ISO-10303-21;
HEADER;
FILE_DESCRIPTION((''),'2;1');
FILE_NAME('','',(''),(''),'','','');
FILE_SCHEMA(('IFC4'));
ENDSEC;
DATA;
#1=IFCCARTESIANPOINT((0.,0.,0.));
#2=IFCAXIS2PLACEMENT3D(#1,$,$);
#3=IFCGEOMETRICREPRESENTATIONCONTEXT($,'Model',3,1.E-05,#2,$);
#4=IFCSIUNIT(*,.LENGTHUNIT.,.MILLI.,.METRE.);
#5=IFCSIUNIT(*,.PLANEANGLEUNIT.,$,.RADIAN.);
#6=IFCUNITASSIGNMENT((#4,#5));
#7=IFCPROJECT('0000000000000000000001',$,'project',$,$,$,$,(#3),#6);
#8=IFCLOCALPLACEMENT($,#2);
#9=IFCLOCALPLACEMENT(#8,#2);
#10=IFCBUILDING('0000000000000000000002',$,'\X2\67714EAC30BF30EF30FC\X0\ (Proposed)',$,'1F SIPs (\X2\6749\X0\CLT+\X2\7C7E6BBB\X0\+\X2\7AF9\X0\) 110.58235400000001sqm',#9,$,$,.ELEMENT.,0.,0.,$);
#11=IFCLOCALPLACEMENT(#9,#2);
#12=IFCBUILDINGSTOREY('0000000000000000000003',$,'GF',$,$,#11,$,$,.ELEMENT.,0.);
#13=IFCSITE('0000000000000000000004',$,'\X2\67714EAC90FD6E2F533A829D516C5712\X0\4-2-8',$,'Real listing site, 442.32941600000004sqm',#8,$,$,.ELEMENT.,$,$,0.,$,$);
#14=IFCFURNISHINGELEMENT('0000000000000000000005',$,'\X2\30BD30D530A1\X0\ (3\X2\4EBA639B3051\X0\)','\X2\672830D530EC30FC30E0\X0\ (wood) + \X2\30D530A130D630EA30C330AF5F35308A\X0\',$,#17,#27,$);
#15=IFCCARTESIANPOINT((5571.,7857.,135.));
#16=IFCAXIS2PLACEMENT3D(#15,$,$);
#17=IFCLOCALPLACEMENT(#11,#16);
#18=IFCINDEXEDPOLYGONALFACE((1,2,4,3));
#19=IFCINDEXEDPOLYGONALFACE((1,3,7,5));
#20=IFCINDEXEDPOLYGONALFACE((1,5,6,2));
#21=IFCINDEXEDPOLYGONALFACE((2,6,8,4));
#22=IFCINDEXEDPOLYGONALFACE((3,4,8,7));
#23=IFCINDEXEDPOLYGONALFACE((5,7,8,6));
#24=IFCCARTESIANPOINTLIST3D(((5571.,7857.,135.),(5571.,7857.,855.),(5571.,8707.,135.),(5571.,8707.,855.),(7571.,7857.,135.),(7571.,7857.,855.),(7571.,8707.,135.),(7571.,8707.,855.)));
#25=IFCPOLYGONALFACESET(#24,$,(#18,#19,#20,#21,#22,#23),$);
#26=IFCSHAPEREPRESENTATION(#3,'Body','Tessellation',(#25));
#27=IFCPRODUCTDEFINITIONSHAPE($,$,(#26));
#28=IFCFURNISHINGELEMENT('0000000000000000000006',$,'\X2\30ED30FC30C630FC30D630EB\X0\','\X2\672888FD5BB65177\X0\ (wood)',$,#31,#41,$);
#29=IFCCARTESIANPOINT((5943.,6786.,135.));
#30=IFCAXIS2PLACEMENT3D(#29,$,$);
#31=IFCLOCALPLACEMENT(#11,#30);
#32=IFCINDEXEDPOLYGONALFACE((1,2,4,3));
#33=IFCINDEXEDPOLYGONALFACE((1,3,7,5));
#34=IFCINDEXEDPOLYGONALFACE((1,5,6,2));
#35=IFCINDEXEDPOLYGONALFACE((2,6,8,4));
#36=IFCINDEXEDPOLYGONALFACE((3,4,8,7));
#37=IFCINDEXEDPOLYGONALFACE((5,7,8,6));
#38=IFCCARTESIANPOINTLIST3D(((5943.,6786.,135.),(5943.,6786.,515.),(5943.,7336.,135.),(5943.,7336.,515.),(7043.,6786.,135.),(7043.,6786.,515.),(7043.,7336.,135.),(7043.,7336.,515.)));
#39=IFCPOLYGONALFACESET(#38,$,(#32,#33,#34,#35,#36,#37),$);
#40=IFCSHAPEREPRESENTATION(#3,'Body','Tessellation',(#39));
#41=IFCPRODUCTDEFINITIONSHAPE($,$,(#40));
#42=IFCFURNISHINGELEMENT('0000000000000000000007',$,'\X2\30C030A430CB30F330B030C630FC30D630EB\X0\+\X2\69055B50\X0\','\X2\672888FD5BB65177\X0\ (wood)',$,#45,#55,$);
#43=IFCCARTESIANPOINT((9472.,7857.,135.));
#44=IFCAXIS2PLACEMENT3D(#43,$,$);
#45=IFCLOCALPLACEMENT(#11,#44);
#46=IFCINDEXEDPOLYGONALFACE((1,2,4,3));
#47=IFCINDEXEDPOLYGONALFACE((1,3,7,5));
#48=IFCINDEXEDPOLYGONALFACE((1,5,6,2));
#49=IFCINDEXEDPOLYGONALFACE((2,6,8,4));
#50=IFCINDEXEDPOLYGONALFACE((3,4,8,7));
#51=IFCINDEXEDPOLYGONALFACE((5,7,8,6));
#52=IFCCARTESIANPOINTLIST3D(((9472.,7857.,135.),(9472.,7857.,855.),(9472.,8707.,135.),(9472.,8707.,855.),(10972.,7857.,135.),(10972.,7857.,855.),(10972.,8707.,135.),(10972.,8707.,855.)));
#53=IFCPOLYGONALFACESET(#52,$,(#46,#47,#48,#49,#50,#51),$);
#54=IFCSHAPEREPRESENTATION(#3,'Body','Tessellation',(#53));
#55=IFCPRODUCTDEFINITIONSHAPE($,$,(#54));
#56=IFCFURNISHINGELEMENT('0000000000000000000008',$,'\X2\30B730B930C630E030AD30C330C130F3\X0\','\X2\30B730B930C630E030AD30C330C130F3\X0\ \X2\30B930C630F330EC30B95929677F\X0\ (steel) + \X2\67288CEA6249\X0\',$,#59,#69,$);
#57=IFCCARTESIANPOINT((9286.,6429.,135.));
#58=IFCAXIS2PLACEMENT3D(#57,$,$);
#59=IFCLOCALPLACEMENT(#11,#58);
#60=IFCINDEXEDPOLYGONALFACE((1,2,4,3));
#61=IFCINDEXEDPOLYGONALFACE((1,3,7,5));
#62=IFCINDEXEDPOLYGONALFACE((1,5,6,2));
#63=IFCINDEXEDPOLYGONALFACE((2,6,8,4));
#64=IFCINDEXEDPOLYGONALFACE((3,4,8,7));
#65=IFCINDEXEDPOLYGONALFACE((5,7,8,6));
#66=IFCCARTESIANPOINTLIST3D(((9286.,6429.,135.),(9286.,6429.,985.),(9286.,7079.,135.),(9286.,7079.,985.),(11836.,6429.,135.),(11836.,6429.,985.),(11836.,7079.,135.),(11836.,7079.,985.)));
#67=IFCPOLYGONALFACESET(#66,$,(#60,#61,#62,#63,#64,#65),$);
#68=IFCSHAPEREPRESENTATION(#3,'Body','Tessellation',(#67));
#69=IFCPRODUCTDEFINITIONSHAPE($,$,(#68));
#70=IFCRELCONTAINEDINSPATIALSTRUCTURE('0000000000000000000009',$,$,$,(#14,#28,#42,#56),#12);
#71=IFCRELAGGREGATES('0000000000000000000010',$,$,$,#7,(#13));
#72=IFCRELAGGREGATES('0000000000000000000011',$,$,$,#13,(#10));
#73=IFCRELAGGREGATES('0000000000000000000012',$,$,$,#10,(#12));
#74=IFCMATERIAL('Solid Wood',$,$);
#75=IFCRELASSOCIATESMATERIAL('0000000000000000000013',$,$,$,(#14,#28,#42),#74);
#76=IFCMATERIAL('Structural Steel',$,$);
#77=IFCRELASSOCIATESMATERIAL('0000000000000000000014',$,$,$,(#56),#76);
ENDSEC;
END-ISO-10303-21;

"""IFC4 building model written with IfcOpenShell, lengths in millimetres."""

from ifc_helpers import new_model, si_unit, frame, frame_2d, origin, place, context, project, spatial, rectangle, extrude, material, element, save


model = new_model("IFC4")

# Units and contexts
model_context = context("Model", 3, precision=1e-05, world=origin())
ifc_project = project(units=[si_unit("LENGTHUNIT", "METRE", prefix="MILLI"), si_unit("PLANEANGLEUNIT", "RADIAN")], contexts=[model_context])

# Site, building, storey
site_placement = place(None, origin())
site = spatial("IfcSite", under=ifc_project, at=site_placement, Name="東京都港区芝公園4-2-8", ObjectType="Real listing site, 442.32941600000004sqm", CompositionType="ELEMENT", RefElevation=0.0)
building_placement = place(site_placement, origin())
building = spatial("IfcBuilding", under=site, at=building_placement, Name="東京タワー (Proposed)", ObjectType="1F SIPs (杉CLT+籾殻+竹) 110.58235400000001sqm", CompositionType="ELEMENT", ElevationOfRefHeight=0.0, ElevationOfTerrain=0.0)
storey_placement = place(building_placement, origin())
storey = spatial("IfcBuildingStorey", under=building, at=storey_placement, Name="GF", CompositionType="ELEMENT", Elevation=0.0)

# Shared definitions
ifc_material_1 = material(Name="Solid Wood")

# Shared definitions
ifc_material_2 = material(Name="Structural Steel")

# Furnishing elements
furnishing_1_placement = place(storey_placement, frame((5571.0, 7857.0, 135.0)))
element("IfcFurnishingElement", 1, at=furnishing_1_placement, inside=storey, material=ifc_material_1, Name="ソファ (3人掛け)", Description="木フレーム (wood) + ファブリック張り", context=model_context, shape_type="SweptSolid", body=[
    extrude(rectangle(XDim=2000.0, YDim=850.0, at=frame_2d((1000.0, 425.0))), frame((5571.0, 7857.0, 135.0)), (0.0, 0.0, 1.0), 720.0),
])
furnishing_2_placement = place(storey_placement, frame((5943.0, 6786.0, 135.0)))
element("IfcFurnishingElement", 2, at=furnishing_2_placement, inside=storey, material=ifc_material_1, Name="ローテーブル", Description="木製家具 (wood)", context=model_context, shape_type="SweptSolid", body=[
    extrude(rectangle(XDim=1100.0, YDim=550.0, at=frame_2d((550.0, 275.0))), frame((5943.0, 6786.0, 135.0)), (0.0, 0.0, 1.0), 380.0),
])
furnishing_3_placement = place(storey_placement, frame((9472.0, 7857.0, 135.0)))
element("IfcFurnishingElement", 3, at=furnishing_3_placement, inside=storey, material=ifc_material_1, Name="ダイニングテーブル+椅子", Description="木製家具 (wood)", context=model_context, shape_type="SweptSolid", body=[
    extrude(rectangle(XDim=1500.0, YDim=850.0, at=frame_2d((750.0, 425.0))), frame((9472.0, 7857.0, 135.0)), (0.0, 0.0, 1.0), 720.0),
])
furnishing_4_placement = place(storey_placement, frame((9286.0, 6429.0, 135.0)))
element("IfcFurnishingElement", 4, at=furnishing_4_placement, inside=storey, material=ifc_material_2, Name="システムキッチン", Description="システムキッチン ステンレス天板 (steel) + 木質扉", context=model_context, shape_type="SweptSolid", body=[
    extrude(rectangle(XDim=2550.0, YDim=650.0, at=frame_2d((1275.0, 325.0))), frame((9286.0, 6429.0, 135.0)), (0.0, 0.0, 1.0), 850.0),
])

save(model, "model.ifc")
